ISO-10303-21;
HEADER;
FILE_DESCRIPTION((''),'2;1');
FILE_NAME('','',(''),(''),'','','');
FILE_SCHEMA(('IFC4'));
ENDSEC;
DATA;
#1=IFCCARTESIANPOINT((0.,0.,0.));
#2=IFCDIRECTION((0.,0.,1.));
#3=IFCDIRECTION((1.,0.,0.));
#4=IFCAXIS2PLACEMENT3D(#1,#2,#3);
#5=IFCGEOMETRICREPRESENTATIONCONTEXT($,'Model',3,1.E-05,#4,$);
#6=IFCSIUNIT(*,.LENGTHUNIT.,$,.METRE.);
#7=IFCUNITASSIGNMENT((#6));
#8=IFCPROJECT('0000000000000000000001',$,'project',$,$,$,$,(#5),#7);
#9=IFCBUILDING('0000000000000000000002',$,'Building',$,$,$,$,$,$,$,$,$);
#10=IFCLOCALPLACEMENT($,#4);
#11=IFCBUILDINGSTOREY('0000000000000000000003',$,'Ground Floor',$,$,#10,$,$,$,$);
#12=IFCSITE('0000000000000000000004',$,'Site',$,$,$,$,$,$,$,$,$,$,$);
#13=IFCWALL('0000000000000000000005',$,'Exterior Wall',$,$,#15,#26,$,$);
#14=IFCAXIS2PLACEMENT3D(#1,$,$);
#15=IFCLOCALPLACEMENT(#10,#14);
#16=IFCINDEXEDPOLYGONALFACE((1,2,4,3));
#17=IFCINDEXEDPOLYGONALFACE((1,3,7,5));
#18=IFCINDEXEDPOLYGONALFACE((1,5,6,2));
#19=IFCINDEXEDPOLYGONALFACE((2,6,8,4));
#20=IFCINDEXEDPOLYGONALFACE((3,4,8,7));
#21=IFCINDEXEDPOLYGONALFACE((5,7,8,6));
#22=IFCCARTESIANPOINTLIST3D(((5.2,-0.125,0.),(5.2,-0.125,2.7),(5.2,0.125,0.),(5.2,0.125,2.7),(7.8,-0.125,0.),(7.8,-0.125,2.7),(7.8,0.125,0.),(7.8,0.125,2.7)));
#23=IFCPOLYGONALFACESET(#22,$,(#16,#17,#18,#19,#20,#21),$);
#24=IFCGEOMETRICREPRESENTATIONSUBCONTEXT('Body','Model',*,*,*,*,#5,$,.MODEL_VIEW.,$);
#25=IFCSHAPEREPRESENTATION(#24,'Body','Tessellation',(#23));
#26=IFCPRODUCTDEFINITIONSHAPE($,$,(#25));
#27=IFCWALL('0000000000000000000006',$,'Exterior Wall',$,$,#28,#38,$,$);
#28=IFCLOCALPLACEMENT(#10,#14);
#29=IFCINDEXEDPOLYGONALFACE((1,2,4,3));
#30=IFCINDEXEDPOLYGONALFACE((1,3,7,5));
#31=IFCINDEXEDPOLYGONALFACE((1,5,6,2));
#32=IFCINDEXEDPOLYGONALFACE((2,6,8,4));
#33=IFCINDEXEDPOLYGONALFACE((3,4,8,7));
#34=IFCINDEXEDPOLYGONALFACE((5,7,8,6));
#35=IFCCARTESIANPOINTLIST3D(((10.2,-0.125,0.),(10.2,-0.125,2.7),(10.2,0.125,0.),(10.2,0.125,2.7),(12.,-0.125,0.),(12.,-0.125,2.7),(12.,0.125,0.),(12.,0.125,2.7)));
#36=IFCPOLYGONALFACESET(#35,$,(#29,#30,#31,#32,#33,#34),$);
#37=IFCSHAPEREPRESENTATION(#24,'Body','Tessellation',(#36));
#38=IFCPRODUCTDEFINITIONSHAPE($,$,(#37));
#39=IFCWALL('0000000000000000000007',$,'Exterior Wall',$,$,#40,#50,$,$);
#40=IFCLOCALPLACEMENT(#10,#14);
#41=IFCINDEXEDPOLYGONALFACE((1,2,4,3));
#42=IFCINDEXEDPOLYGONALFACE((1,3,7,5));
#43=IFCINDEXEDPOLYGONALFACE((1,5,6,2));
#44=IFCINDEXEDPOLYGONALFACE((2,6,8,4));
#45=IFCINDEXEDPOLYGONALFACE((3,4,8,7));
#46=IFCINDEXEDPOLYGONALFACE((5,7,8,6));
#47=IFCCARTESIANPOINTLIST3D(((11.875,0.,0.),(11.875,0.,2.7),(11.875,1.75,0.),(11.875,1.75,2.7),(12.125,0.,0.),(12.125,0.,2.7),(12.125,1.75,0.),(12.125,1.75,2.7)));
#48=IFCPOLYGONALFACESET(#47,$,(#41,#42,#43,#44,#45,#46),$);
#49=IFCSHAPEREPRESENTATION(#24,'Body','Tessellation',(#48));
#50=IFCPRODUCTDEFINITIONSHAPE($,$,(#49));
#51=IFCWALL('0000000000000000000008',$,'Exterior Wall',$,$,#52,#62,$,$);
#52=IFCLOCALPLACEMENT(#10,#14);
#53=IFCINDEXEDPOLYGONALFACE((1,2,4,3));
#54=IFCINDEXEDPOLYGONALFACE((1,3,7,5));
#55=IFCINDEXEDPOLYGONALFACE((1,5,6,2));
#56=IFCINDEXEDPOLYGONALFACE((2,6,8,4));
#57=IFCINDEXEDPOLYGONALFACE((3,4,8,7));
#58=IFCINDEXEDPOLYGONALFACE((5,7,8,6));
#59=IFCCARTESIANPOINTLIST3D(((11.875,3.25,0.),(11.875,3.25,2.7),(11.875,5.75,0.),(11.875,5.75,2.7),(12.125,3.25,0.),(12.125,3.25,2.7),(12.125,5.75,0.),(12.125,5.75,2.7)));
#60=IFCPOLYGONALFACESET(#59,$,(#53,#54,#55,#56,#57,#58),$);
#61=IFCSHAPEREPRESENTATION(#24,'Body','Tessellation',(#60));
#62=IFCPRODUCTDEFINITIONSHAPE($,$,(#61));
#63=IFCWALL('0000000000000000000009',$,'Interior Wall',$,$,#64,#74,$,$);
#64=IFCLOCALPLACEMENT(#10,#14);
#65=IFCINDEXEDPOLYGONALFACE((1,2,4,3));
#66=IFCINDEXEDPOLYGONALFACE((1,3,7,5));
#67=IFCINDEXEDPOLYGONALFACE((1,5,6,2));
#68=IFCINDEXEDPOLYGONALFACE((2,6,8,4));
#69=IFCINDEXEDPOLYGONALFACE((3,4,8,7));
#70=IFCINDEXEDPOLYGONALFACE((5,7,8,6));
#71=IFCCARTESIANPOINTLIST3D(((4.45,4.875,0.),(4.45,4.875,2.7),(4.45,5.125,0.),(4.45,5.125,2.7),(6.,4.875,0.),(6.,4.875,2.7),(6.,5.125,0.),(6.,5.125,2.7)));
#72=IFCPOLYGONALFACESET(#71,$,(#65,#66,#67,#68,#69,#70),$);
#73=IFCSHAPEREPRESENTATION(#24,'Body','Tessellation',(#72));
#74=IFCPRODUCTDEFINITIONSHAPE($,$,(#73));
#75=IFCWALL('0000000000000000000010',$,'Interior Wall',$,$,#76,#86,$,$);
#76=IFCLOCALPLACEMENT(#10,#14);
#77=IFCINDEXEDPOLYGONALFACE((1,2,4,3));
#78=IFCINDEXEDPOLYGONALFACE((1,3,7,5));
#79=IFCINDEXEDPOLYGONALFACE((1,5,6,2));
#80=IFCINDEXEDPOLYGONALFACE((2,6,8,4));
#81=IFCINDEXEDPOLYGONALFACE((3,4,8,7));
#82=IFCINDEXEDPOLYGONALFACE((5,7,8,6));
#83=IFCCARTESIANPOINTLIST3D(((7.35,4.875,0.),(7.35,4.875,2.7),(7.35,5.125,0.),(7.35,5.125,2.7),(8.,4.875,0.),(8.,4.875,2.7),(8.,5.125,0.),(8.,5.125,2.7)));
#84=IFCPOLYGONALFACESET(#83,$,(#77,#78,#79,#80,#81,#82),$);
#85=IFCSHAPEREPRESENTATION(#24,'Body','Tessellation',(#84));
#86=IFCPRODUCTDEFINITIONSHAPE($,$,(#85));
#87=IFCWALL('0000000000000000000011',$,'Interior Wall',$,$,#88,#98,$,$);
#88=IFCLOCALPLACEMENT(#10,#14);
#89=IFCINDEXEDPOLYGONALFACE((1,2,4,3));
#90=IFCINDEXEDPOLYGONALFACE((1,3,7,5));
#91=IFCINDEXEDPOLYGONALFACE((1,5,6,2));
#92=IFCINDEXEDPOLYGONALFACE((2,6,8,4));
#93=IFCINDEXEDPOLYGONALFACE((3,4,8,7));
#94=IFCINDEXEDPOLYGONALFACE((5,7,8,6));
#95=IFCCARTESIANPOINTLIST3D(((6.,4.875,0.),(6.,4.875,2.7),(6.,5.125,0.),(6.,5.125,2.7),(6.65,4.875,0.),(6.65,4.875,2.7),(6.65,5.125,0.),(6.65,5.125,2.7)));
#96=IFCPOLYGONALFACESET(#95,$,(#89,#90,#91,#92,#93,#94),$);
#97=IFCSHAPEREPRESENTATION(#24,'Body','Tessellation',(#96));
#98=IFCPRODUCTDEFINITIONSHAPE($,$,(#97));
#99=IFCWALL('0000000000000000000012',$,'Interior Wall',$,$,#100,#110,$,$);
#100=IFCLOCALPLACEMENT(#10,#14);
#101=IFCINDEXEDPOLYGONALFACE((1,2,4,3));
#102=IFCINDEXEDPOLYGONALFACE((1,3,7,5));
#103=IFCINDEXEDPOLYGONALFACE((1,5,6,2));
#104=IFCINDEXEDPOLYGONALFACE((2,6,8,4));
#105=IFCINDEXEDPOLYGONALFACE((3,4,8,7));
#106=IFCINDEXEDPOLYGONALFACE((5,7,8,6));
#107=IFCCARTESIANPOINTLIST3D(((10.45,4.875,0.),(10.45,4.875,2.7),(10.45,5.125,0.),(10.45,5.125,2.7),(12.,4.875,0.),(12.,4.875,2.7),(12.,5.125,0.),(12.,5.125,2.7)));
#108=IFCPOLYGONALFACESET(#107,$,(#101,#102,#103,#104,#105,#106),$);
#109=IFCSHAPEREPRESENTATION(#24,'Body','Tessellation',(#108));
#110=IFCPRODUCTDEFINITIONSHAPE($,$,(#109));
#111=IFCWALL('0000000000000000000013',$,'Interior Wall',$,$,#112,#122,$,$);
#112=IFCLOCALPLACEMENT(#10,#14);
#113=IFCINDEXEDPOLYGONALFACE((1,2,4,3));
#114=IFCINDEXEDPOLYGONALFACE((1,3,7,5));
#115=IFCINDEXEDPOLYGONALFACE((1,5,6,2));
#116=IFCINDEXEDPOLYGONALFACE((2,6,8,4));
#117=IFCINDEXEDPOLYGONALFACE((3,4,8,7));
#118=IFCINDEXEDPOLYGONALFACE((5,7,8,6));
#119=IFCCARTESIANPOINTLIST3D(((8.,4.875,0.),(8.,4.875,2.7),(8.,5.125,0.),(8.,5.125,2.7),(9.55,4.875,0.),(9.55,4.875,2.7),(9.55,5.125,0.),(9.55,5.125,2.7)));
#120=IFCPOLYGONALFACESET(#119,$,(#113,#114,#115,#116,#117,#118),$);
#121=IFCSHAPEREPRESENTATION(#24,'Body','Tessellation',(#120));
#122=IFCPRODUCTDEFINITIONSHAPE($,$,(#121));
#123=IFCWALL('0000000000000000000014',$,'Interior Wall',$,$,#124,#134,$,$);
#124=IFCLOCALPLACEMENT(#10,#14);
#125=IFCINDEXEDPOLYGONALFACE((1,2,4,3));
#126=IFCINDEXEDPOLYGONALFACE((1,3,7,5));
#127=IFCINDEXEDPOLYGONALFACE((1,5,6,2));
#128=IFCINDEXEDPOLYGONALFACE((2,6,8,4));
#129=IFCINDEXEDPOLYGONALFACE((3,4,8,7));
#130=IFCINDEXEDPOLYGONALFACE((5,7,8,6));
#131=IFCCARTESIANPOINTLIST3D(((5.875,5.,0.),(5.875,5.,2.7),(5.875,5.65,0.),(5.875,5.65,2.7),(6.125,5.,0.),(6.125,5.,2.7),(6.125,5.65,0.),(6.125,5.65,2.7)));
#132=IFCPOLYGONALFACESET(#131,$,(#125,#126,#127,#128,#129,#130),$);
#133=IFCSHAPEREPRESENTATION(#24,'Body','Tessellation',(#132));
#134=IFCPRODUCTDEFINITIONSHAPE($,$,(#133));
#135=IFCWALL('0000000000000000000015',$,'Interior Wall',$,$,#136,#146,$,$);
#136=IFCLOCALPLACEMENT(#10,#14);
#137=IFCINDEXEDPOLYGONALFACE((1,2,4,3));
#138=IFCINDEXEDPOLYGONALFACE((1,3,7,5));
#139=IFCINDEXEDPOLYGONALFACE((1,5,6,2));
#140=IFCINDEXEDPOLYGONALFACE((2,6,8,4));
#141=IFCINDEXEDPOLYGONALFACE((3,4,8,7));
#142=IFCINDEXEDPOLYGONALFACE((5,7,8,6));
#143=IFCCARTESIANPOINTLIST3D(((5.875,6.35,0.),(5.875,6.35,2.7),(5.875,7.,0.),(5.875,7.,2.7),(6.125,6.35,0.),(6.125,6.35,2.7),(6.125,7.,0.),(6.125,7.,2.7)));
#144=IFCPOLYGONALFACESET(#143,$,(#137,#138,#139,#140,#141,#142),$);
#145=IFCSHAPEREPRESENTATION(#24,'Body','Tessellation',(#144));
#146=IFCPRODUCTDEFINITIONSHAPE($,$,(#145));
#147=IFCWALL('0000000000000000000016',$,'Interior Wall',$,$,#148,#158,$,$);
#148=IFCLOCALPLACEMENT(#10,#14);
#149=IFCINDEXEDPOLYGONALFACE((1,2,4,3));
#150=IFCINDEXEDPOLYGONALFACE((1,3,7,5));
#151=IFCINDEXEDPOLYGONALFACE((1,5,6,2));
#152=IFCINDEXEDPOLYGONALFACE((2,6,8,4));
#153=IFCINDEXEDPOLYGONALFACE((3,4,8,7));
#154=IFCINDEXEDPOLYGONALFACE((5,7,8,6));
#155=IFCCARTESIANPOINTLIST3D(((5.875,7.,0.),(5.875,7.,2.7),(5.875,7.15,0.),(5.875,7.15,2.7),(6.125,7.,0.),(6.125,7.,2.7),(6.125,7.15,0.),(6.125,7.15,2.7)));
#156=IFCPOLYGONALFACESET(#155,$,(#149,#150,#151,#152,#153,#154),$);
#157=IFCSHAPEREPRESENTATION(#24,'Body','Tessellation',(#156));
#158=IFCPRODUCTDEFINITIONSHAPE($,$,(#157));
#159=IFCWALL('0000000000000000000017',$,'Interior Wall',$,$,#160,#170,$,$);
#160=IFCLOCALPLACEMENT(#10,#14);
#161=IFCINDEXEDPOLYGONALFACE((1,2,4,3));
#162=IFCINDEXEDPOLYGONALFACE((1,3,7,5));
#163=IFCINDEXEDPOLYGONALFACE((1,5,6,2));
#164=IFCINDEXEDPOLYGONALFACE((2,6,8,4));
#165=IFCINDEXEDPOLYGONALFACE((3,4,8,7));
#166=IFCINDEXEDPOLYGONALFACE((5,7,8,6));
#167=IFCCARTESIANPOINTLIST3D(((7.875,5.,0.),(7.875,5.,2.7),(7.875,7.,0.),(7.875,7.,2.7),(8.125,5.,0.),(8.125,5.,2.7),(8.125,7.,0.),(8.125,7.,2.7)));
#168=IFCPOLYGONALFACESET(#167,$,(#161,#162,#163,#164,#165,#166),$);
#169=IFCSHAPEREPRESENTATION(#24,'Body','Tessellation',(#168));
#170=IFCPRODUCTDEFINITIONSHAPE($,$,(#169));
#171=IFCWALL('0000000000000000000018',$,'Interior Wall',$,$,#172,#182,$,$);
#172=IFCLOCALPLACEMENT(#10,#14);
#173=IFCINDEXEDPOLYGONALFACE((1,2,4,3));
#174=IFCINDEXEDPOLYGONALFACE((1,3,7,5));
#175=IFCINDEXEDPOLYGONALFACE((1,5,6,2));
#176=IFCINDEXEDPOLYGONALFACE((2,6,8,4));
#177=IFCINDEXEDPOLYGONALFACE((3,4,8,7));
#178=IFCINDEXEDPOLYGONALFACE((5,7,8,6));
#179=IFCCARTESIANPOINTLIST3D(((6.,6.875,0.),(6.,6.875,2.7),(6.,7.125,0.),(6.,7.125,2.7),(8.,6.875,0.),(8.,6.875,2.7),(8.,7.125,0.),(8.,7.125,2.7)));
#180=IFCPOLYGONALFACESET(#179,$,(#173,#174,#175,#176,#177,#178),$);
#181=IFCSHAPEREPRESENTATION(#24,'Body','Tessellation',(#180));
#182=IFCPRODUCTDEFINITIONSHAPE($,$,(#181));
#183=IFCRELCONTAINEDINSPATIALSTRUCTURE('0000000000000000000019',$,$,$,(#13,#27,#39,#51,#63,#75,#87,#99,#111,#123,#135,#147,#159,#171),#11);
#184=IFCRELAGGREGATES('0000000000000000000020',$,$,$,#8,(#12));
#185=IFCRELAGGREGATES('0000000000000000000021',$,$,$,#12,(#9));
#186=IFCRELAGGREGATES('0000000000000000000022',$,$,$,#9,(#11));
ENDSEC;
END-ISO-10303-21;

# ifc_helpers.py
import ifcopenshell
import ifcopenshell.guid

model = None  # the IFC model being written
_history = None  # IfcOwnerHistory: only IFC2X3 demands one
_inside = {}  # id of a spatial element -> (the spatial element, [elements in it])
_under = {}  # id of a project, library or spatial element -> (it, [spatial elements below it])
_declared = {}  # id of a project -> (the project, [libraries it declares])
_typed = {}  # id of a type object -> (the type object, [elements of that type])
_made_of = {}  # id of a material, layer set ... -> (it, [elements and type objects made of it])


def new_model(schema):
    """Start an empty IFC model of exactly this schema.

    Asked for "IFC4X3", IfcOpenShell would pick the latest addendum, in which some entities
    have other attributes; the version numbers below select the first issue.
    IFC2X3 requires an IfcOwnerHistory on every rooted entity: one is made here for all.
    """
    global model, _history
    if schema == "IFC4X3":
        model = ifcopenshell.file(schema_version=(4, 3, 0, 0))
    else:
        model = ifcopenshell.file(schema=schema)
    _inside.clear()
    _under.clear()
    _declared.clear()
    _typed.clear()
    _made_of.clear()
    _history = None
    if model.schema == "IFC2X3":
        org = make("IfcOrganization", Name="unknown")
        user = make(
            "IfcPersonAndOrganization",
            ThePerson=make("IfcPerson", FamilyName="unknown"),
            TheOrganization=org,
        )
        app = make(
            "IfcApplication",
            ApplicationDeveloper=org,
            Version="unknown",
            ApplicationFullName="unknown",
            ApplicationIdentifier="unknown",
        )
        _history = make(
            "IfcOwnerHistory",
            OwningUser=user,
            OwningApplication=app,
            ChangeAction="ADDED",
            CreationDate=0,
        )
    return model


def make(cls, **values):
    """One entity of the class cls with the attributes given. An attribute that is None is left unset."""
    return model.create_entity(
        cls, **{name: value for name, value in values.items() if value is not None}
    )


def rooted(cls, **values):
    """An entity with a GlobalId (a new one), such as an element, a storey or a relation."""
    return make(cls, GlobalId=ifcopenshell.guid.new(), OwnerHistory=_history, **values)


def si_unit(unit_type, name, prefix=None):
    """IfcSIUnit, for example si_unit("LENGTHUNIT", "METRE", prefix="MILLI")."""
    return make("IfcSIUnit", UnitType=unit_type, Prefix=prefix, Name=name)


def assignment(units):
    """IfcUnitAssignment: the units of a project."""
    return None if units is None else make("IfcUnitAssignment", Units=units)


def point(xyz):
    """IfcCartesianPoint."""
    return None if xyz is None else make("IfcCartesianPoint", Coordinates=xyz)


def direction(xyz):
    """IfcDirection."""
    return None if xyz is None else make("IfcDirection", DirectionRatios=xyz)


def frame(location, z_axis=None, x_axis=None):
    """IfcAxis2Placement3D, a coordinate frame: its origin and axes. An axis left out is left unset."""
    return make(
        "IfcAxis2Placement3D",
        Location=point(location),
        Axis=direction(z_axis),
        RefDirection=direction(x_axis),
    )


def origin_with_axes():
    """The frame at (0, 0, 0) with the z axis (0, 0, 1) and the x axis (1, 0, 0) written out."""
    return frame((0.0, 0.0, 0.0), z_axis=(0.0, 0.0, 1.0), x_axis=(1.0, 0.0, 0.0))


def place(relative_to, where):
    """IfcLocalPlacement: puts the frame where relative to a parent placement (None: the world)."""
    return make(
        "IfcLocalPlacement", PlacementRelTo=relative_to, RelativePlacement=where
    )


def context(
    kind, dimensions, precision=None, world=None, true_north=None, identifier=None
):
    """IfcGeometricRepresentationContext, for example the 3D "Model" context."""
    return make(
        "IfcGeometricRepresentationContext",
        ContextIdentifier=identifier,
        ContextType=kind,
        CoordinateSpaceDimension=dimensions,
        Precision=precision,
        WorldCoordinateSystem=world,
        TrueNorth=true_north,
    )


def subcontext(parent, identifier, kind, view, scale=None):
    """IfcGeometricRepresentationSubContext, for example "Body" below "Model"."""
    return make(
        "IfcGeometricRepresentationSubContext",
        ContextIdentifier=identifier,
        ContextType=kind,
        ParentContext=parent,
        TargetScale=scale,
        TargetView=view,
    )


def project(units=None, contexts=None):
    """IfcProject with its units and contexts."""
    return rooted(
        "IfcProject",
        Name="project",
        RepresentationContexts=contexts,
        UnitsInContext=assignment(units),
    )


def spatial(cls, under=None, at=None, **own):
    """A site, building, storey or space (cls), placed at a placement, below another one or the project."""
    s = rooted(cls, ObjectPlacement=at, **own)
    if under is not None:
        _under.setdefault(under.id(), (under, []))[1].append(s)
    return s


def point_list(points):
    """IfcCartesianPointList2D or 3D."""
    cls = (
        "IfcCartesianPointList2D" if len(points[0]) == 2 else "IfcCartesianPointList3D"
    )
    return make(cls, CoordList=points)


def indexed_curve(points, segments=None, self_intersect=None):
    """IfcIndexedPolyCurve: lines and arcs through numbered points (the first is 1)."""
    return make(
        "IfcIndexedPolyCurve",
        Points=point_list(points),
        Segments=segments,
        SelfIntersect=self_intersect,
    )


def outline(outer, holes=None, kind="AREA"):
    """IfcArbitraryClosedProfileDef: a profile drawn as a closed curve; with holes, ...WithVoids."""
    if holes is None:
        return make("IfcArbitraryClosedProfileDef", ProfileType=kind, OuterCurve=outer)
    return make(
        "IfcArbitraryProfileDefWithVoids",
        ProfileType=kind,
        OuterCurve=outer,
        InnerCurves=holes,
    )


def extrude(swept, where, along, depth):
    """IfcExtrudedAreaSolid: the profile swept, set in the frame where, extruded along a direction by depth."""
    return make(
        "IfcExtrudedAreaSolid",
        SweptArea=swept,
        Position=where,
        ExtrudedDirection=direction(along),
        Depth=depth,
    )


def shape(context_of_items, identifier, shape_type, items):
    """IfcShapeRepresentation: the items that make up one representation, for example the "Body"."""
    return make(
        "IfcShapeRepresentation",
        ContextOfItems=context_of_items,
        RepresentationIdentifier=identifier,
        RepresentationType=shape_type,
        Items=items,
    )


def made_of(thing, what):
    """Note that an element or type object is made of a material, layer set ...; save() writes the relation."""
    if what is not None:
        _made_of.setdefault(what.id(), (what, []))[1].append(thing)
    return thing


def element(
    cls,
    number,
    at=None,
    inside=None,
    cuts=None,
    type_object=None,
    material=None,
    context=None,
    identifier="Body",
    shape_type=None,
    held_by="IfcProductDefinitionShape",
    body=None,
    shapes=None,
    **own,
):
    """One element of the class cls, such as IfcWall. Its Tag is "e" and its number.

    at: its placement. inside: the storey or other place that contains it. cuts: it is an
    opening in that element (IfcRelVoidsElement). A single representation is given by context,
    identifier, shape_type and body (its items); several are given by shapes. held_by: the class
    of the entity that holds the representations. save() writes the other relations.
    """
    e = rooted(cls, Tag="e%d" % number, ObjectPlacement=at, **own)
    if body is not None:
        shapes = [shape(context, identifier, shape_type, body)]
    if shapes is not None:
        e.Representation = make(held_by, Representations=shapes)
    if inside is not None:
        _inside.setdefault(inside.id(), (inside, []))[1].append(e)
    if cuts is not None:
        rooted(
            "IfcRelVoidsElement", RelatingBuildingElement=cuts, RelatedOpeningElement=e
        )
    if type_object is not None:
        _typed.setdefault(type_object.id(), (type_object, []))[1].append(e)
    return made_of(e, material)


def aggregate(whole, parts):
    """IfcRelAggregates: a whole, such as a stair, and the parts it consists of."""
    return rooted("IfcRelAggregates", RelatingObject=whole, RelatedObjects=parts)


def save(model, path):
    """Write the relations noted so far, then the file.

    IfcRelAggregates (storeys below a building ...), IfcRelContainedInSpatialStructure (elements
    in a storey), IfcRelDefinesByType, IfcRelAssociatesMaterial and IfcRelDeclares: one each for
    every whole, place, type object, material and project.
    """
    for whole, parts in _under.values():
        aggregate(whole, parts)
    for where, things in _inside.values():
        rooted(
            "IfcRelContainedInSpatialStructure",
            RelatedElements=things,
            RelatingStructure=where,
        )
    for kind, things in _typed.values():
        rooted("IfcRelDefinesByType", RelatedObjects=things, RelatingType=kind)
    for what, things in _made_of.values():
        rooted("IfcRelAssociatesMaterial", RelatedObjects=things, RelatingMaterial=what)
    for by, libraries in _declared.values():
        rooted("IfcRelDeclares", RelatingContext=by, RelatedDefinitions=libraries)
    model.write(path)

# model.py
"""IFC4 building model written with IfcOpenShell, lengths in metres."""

from ifc_helpers import new_model, si_unit, frame, origin_with_axes, place, context, subcontext, project, spatial, indexed_curve, outline, extrude, element, save


model = new_model("IFC4")

# Units and contexts
model_context = context("Model", 3, precision=1e-05, world=origin_with_axes())
body_context = subcontext(model_context, "Body", "Model", "MODEL_VIEW")
ifc_project = project(units=[si_unit("LENGTHUNIT", "METRE")], contexts=[model_context])

# Site, building, storey
site = spatial("IfcSite", under=ifc_project, Name="Site")
building = spatial("IfcBuilding", under=site, Name="Building")
storey_placement = place(None, origin_with_axes())
storey = spatial("IfcBuildingStorey", under=building, at=storey_placement, Name="Ground Floor")

# Walls
wall_1_placement = place(storey_placement, frame((5.2, 0.0, 0.0), z_axis=(0.0, 0.0, 1.0), x_axis=(1.0, 0.0, 0.0)))
element("IfcWall", 1, at=wall_1_placement, inside=storey, Name="Exterior Wall", context=body_context, shape_type="SweptSolid", body=[
    extrude(outline(indexed_curve([(0.0, 0.0), (0.0, 0.25), (2.6, 0.25), (2.6, 0.0), (0.0, 0.0)], self_intersect=False)), frame((0.0, -0.125, 0.0), z_axis=(0.0, 0.0, 1.0), x_axis=(1.0, 0.0, 0.0)), (0.0, 0.0, 1.0), 2.7),
])
wall_2_placement = place(storey_placement, frame((10.2, 0.0, 0.0), z_axis=(0.0, 0.0, 1.0), x_axis=(1.0, 0.0, 0.0)))
element("IfcWall", 2, at=wall_2_placement, inside=storey, Name="Exterior Wall", context=body_context, shape_type="SweptSolid", body=[
    extrude(outline(indexed_curve([(0.0, 0.0), (0.0, 0.25), (1.8, 0.25), (1.8, 0.0), (0.0, 0.0)], self_intersect=False)), frame((0.0, -0.125, 0.0), z_axis=(0.0, 0.0, 1.0), x_axis=(1.0, 0.0, 0.0)), (0.0, 0.0, 1.0), 2.7),
])
wall_3_placement = place(storey_placement, frame((12.0, 0.0, 0.0), z_axis=(0.0, 0.0, 1.0), x_axis=(0.0, 1.0, 0.0)))
element("IfcWall", 3, at=wall_3_placement, inside=storey, Name="Exterior Wall", context=body_context, shape_type="SweptSolid", body=[
    extrude(outline(indexed_curve([(0.0, 0.0), (0.0, 0.25), (1.75, 0.25), (1.75, 0.0), (0.0, 0.0)], self_intersect=False)), frame((0.0, -0.125, 0.0), z_axis=(0.0, 0.0, 1.0), x_axis=(1.0, 0.0, 0.0)), (0.0, 0.0, 1.0), 2.7),
])
wall_4_placement = place(storey_placement, frame((12.0, 3.25, 0.0), z_axis=(0.0, 0.0, 1.0), x_axis=(0.0, 1.0, 0.0)))
element("IfcWall", 4, at=wall_4_placement, inside=storey, Name="Exterior Wall", context=body_context, shape_type="SweptSolid", body=[
    extrude(outline(indexed_curve([(0.0, 0.0), (0.0, 0.25), (2.5, 0.25), (2.5, 0.0), (0.0, 0.0)], self_intersect=False)), frame((0.0, -0.125, 0.0), z_axis=(0.0, 0.0, 1.0), x_axis=(1.0, 0.0, 0.0)), (0.0, 0.0, 1.0), 2.7),
])
wall_5_placement = place(storey_placement, frame((6.0, 5.0, 0.0), z_axis=(0.0, 0.0, 1.0), x_axis=(-1.0, 0.0, 0.0)))
element("IfcWall", 5, at=wall_5_placement, inside=storey, Name="Interior Wall", context=body_context, shape_type="SweptSolid", body=[
    extrude(outline(indexed_curve([(0.0, 0.0), (0.0, 0.25), (1.55, 0.25), (1.55, 0.0), (0.0, 0.0)], self_intersect=False)), frame((0.0, -0.125, 0.0), z_axis=(0.0, 0.0, 1.0), x_axis=(1.0, 0.0, 0.0)), (0.0, 0.0, 1.0), 2.7),
])
for number, where, z_axis, x_axis, name in (
    (6, (8.0, 5.0, 0.0), (0.0, 0.0, 1.0), (-1.0, 0.0, 0.0), "Interior Wall"),
    (7, (6.65, 5.0, 0.0), (0.0, 0.0, 1.0), (-1.0, 0.0, 0.0), "Interior Wall"),
):
    element("IfcWall", number, at=place(storey_placement, frame(where, z_axis=z_axis, x_axis=x_axis)), inside=storey, Name=name, context=body_context, shape_type="SweptSolid", body=[
        extrude(outline(indexed_curve([(0.0, 0.0), (0.0, 0.25), (0.65, 0.25), (0.65, 0.0), (0.0, 0.0)], self_intersect=False)), frame((0.0, -0.125, 0.0), z_axis=(0.0, 0.0, 1.0), x_axis=(1.0, 0.0, 0.0)), (0.0, 0.0, 1.0), 2.7),
    ])
for number, where, z_axis, x_axis, name in (
    (8, (12.0, 5.0, 0.0), (0.0, 0.0, 1.0), (-1.0, 0.0, 0.0), "Interior Wall"),
    (9, (9.55, 5.0, 0.0), (0.0, 0.0, 1.0), (-1.0, 0.0, 0.0), "Interior Wall"),
):
    element("IfcWall", number, at=place(storey_placement, frame(where, z_axis=z_axis, x_axis=x_axis)), inside=storey, Name=name, context=body_context, shape_type="SweptSolid", body=[
        extrude(outline(indexed_curve([(0.0, 0.0), (0.0, 0.25), (1.55, 0.25), (1.55, 0.0), (0.0, 0.0)], self_intersect=False)), frame((0.0, -0.125, 0.0), z_axis=(0.0, 0.0, 1.0), x_axis=(1.0, 0.0, 0.0)), (0.0, 0.0, 1.0), 2.7),
    ])
for number, where, z_axis, x_axis, name in (
    (10, (6.0, 5.0, 0.0), (0.0, 0.0, 1.0), (0.0, 1.0, 0.0), "Interior Wall"),
    (11, (6.0, 6.35, 0.0), (0.0, 0.0, 1.0), (0.0, 1.0, 0.0), "Interior Wall"),
):
    element("IfcWall", number, at=place(storey_placement, frame(where, z_axis=z_axis, x_axis=x_axis)), inside=storey, Name=name, context=body_context, shape_type="SweptSolid", body=[
        extrude(outline(indexed_curve([(0.0, 0.0), (0.0, 0.25), (0.65, 0.25), (0.65, 0.0), (0.0, 0.0)], self_intersect=False)), frame((0.0, -0.125, 0.0), z_axis=(0.0, 0.0, 1.0), x_axis=(1.0, 0.0, 0.0)), (0.0, 0.0, 1.0), 2.7),
    ])
wall_6_placement = place(storey_placement, frame((6.0, 7.0, 0.0), z_axis=(0.0, 0.0, 1.0), x_axis=(0.0, 1.0, 0.0)))
element("IfcWall", 12, at=wall_6_placement, inside=storey, Name="Interior Wall", context=body_context, shape_type="SweptSolid", body=[
    extrude(outline(indexed_curve([(0.0, 0.0), (0.0, 0.25), (0.15, 0.25), (0.15, 0.0), (0.0, 0.0)], self_intersect=False)), frame((0.0, -0.125, 0.0), z_axis=(0.0, 0.0, 1.0), x_axis=(1.0, 0.0, 0.0)), (0.0, 0.0, 1.0), 2.7),
])
for number, where, z_axis, x_axis, name in (
    (13, (8.0, 5.0, 0.0), (0.0, 0.0, 1.0), (0.0, 1.0, 0.0), "Interior Wall"),
    (14, (8.0, 7.0, 0.0), (0.0, 0.0, 1.0), (-1.0, 0.0, 0.0), "Interior Wall"),
):
    element("IfcWall", number, at=place(storey_placement, frame(where, z_axis=z_axis, x_axis=x_axis)), inside=storey, Name=name, context=body_context, shape_type="SweptSolid", body=[
        extrude(outline(indexed_curve([(0.0, 0.0), (0.0, 0.25), (2.0, 0.25), (2.0, 0.0), (0.0, 0.0)], self_intersect=False)), frame((0.0, -0.125, 0.0), z_axis=(0.0, 0.0, 1.0), x_axis=(1.0, 0.0, 0.0)), (0.0, 0.0, 1.0), 2.7),
    ])

save(model, "model.ifc")
